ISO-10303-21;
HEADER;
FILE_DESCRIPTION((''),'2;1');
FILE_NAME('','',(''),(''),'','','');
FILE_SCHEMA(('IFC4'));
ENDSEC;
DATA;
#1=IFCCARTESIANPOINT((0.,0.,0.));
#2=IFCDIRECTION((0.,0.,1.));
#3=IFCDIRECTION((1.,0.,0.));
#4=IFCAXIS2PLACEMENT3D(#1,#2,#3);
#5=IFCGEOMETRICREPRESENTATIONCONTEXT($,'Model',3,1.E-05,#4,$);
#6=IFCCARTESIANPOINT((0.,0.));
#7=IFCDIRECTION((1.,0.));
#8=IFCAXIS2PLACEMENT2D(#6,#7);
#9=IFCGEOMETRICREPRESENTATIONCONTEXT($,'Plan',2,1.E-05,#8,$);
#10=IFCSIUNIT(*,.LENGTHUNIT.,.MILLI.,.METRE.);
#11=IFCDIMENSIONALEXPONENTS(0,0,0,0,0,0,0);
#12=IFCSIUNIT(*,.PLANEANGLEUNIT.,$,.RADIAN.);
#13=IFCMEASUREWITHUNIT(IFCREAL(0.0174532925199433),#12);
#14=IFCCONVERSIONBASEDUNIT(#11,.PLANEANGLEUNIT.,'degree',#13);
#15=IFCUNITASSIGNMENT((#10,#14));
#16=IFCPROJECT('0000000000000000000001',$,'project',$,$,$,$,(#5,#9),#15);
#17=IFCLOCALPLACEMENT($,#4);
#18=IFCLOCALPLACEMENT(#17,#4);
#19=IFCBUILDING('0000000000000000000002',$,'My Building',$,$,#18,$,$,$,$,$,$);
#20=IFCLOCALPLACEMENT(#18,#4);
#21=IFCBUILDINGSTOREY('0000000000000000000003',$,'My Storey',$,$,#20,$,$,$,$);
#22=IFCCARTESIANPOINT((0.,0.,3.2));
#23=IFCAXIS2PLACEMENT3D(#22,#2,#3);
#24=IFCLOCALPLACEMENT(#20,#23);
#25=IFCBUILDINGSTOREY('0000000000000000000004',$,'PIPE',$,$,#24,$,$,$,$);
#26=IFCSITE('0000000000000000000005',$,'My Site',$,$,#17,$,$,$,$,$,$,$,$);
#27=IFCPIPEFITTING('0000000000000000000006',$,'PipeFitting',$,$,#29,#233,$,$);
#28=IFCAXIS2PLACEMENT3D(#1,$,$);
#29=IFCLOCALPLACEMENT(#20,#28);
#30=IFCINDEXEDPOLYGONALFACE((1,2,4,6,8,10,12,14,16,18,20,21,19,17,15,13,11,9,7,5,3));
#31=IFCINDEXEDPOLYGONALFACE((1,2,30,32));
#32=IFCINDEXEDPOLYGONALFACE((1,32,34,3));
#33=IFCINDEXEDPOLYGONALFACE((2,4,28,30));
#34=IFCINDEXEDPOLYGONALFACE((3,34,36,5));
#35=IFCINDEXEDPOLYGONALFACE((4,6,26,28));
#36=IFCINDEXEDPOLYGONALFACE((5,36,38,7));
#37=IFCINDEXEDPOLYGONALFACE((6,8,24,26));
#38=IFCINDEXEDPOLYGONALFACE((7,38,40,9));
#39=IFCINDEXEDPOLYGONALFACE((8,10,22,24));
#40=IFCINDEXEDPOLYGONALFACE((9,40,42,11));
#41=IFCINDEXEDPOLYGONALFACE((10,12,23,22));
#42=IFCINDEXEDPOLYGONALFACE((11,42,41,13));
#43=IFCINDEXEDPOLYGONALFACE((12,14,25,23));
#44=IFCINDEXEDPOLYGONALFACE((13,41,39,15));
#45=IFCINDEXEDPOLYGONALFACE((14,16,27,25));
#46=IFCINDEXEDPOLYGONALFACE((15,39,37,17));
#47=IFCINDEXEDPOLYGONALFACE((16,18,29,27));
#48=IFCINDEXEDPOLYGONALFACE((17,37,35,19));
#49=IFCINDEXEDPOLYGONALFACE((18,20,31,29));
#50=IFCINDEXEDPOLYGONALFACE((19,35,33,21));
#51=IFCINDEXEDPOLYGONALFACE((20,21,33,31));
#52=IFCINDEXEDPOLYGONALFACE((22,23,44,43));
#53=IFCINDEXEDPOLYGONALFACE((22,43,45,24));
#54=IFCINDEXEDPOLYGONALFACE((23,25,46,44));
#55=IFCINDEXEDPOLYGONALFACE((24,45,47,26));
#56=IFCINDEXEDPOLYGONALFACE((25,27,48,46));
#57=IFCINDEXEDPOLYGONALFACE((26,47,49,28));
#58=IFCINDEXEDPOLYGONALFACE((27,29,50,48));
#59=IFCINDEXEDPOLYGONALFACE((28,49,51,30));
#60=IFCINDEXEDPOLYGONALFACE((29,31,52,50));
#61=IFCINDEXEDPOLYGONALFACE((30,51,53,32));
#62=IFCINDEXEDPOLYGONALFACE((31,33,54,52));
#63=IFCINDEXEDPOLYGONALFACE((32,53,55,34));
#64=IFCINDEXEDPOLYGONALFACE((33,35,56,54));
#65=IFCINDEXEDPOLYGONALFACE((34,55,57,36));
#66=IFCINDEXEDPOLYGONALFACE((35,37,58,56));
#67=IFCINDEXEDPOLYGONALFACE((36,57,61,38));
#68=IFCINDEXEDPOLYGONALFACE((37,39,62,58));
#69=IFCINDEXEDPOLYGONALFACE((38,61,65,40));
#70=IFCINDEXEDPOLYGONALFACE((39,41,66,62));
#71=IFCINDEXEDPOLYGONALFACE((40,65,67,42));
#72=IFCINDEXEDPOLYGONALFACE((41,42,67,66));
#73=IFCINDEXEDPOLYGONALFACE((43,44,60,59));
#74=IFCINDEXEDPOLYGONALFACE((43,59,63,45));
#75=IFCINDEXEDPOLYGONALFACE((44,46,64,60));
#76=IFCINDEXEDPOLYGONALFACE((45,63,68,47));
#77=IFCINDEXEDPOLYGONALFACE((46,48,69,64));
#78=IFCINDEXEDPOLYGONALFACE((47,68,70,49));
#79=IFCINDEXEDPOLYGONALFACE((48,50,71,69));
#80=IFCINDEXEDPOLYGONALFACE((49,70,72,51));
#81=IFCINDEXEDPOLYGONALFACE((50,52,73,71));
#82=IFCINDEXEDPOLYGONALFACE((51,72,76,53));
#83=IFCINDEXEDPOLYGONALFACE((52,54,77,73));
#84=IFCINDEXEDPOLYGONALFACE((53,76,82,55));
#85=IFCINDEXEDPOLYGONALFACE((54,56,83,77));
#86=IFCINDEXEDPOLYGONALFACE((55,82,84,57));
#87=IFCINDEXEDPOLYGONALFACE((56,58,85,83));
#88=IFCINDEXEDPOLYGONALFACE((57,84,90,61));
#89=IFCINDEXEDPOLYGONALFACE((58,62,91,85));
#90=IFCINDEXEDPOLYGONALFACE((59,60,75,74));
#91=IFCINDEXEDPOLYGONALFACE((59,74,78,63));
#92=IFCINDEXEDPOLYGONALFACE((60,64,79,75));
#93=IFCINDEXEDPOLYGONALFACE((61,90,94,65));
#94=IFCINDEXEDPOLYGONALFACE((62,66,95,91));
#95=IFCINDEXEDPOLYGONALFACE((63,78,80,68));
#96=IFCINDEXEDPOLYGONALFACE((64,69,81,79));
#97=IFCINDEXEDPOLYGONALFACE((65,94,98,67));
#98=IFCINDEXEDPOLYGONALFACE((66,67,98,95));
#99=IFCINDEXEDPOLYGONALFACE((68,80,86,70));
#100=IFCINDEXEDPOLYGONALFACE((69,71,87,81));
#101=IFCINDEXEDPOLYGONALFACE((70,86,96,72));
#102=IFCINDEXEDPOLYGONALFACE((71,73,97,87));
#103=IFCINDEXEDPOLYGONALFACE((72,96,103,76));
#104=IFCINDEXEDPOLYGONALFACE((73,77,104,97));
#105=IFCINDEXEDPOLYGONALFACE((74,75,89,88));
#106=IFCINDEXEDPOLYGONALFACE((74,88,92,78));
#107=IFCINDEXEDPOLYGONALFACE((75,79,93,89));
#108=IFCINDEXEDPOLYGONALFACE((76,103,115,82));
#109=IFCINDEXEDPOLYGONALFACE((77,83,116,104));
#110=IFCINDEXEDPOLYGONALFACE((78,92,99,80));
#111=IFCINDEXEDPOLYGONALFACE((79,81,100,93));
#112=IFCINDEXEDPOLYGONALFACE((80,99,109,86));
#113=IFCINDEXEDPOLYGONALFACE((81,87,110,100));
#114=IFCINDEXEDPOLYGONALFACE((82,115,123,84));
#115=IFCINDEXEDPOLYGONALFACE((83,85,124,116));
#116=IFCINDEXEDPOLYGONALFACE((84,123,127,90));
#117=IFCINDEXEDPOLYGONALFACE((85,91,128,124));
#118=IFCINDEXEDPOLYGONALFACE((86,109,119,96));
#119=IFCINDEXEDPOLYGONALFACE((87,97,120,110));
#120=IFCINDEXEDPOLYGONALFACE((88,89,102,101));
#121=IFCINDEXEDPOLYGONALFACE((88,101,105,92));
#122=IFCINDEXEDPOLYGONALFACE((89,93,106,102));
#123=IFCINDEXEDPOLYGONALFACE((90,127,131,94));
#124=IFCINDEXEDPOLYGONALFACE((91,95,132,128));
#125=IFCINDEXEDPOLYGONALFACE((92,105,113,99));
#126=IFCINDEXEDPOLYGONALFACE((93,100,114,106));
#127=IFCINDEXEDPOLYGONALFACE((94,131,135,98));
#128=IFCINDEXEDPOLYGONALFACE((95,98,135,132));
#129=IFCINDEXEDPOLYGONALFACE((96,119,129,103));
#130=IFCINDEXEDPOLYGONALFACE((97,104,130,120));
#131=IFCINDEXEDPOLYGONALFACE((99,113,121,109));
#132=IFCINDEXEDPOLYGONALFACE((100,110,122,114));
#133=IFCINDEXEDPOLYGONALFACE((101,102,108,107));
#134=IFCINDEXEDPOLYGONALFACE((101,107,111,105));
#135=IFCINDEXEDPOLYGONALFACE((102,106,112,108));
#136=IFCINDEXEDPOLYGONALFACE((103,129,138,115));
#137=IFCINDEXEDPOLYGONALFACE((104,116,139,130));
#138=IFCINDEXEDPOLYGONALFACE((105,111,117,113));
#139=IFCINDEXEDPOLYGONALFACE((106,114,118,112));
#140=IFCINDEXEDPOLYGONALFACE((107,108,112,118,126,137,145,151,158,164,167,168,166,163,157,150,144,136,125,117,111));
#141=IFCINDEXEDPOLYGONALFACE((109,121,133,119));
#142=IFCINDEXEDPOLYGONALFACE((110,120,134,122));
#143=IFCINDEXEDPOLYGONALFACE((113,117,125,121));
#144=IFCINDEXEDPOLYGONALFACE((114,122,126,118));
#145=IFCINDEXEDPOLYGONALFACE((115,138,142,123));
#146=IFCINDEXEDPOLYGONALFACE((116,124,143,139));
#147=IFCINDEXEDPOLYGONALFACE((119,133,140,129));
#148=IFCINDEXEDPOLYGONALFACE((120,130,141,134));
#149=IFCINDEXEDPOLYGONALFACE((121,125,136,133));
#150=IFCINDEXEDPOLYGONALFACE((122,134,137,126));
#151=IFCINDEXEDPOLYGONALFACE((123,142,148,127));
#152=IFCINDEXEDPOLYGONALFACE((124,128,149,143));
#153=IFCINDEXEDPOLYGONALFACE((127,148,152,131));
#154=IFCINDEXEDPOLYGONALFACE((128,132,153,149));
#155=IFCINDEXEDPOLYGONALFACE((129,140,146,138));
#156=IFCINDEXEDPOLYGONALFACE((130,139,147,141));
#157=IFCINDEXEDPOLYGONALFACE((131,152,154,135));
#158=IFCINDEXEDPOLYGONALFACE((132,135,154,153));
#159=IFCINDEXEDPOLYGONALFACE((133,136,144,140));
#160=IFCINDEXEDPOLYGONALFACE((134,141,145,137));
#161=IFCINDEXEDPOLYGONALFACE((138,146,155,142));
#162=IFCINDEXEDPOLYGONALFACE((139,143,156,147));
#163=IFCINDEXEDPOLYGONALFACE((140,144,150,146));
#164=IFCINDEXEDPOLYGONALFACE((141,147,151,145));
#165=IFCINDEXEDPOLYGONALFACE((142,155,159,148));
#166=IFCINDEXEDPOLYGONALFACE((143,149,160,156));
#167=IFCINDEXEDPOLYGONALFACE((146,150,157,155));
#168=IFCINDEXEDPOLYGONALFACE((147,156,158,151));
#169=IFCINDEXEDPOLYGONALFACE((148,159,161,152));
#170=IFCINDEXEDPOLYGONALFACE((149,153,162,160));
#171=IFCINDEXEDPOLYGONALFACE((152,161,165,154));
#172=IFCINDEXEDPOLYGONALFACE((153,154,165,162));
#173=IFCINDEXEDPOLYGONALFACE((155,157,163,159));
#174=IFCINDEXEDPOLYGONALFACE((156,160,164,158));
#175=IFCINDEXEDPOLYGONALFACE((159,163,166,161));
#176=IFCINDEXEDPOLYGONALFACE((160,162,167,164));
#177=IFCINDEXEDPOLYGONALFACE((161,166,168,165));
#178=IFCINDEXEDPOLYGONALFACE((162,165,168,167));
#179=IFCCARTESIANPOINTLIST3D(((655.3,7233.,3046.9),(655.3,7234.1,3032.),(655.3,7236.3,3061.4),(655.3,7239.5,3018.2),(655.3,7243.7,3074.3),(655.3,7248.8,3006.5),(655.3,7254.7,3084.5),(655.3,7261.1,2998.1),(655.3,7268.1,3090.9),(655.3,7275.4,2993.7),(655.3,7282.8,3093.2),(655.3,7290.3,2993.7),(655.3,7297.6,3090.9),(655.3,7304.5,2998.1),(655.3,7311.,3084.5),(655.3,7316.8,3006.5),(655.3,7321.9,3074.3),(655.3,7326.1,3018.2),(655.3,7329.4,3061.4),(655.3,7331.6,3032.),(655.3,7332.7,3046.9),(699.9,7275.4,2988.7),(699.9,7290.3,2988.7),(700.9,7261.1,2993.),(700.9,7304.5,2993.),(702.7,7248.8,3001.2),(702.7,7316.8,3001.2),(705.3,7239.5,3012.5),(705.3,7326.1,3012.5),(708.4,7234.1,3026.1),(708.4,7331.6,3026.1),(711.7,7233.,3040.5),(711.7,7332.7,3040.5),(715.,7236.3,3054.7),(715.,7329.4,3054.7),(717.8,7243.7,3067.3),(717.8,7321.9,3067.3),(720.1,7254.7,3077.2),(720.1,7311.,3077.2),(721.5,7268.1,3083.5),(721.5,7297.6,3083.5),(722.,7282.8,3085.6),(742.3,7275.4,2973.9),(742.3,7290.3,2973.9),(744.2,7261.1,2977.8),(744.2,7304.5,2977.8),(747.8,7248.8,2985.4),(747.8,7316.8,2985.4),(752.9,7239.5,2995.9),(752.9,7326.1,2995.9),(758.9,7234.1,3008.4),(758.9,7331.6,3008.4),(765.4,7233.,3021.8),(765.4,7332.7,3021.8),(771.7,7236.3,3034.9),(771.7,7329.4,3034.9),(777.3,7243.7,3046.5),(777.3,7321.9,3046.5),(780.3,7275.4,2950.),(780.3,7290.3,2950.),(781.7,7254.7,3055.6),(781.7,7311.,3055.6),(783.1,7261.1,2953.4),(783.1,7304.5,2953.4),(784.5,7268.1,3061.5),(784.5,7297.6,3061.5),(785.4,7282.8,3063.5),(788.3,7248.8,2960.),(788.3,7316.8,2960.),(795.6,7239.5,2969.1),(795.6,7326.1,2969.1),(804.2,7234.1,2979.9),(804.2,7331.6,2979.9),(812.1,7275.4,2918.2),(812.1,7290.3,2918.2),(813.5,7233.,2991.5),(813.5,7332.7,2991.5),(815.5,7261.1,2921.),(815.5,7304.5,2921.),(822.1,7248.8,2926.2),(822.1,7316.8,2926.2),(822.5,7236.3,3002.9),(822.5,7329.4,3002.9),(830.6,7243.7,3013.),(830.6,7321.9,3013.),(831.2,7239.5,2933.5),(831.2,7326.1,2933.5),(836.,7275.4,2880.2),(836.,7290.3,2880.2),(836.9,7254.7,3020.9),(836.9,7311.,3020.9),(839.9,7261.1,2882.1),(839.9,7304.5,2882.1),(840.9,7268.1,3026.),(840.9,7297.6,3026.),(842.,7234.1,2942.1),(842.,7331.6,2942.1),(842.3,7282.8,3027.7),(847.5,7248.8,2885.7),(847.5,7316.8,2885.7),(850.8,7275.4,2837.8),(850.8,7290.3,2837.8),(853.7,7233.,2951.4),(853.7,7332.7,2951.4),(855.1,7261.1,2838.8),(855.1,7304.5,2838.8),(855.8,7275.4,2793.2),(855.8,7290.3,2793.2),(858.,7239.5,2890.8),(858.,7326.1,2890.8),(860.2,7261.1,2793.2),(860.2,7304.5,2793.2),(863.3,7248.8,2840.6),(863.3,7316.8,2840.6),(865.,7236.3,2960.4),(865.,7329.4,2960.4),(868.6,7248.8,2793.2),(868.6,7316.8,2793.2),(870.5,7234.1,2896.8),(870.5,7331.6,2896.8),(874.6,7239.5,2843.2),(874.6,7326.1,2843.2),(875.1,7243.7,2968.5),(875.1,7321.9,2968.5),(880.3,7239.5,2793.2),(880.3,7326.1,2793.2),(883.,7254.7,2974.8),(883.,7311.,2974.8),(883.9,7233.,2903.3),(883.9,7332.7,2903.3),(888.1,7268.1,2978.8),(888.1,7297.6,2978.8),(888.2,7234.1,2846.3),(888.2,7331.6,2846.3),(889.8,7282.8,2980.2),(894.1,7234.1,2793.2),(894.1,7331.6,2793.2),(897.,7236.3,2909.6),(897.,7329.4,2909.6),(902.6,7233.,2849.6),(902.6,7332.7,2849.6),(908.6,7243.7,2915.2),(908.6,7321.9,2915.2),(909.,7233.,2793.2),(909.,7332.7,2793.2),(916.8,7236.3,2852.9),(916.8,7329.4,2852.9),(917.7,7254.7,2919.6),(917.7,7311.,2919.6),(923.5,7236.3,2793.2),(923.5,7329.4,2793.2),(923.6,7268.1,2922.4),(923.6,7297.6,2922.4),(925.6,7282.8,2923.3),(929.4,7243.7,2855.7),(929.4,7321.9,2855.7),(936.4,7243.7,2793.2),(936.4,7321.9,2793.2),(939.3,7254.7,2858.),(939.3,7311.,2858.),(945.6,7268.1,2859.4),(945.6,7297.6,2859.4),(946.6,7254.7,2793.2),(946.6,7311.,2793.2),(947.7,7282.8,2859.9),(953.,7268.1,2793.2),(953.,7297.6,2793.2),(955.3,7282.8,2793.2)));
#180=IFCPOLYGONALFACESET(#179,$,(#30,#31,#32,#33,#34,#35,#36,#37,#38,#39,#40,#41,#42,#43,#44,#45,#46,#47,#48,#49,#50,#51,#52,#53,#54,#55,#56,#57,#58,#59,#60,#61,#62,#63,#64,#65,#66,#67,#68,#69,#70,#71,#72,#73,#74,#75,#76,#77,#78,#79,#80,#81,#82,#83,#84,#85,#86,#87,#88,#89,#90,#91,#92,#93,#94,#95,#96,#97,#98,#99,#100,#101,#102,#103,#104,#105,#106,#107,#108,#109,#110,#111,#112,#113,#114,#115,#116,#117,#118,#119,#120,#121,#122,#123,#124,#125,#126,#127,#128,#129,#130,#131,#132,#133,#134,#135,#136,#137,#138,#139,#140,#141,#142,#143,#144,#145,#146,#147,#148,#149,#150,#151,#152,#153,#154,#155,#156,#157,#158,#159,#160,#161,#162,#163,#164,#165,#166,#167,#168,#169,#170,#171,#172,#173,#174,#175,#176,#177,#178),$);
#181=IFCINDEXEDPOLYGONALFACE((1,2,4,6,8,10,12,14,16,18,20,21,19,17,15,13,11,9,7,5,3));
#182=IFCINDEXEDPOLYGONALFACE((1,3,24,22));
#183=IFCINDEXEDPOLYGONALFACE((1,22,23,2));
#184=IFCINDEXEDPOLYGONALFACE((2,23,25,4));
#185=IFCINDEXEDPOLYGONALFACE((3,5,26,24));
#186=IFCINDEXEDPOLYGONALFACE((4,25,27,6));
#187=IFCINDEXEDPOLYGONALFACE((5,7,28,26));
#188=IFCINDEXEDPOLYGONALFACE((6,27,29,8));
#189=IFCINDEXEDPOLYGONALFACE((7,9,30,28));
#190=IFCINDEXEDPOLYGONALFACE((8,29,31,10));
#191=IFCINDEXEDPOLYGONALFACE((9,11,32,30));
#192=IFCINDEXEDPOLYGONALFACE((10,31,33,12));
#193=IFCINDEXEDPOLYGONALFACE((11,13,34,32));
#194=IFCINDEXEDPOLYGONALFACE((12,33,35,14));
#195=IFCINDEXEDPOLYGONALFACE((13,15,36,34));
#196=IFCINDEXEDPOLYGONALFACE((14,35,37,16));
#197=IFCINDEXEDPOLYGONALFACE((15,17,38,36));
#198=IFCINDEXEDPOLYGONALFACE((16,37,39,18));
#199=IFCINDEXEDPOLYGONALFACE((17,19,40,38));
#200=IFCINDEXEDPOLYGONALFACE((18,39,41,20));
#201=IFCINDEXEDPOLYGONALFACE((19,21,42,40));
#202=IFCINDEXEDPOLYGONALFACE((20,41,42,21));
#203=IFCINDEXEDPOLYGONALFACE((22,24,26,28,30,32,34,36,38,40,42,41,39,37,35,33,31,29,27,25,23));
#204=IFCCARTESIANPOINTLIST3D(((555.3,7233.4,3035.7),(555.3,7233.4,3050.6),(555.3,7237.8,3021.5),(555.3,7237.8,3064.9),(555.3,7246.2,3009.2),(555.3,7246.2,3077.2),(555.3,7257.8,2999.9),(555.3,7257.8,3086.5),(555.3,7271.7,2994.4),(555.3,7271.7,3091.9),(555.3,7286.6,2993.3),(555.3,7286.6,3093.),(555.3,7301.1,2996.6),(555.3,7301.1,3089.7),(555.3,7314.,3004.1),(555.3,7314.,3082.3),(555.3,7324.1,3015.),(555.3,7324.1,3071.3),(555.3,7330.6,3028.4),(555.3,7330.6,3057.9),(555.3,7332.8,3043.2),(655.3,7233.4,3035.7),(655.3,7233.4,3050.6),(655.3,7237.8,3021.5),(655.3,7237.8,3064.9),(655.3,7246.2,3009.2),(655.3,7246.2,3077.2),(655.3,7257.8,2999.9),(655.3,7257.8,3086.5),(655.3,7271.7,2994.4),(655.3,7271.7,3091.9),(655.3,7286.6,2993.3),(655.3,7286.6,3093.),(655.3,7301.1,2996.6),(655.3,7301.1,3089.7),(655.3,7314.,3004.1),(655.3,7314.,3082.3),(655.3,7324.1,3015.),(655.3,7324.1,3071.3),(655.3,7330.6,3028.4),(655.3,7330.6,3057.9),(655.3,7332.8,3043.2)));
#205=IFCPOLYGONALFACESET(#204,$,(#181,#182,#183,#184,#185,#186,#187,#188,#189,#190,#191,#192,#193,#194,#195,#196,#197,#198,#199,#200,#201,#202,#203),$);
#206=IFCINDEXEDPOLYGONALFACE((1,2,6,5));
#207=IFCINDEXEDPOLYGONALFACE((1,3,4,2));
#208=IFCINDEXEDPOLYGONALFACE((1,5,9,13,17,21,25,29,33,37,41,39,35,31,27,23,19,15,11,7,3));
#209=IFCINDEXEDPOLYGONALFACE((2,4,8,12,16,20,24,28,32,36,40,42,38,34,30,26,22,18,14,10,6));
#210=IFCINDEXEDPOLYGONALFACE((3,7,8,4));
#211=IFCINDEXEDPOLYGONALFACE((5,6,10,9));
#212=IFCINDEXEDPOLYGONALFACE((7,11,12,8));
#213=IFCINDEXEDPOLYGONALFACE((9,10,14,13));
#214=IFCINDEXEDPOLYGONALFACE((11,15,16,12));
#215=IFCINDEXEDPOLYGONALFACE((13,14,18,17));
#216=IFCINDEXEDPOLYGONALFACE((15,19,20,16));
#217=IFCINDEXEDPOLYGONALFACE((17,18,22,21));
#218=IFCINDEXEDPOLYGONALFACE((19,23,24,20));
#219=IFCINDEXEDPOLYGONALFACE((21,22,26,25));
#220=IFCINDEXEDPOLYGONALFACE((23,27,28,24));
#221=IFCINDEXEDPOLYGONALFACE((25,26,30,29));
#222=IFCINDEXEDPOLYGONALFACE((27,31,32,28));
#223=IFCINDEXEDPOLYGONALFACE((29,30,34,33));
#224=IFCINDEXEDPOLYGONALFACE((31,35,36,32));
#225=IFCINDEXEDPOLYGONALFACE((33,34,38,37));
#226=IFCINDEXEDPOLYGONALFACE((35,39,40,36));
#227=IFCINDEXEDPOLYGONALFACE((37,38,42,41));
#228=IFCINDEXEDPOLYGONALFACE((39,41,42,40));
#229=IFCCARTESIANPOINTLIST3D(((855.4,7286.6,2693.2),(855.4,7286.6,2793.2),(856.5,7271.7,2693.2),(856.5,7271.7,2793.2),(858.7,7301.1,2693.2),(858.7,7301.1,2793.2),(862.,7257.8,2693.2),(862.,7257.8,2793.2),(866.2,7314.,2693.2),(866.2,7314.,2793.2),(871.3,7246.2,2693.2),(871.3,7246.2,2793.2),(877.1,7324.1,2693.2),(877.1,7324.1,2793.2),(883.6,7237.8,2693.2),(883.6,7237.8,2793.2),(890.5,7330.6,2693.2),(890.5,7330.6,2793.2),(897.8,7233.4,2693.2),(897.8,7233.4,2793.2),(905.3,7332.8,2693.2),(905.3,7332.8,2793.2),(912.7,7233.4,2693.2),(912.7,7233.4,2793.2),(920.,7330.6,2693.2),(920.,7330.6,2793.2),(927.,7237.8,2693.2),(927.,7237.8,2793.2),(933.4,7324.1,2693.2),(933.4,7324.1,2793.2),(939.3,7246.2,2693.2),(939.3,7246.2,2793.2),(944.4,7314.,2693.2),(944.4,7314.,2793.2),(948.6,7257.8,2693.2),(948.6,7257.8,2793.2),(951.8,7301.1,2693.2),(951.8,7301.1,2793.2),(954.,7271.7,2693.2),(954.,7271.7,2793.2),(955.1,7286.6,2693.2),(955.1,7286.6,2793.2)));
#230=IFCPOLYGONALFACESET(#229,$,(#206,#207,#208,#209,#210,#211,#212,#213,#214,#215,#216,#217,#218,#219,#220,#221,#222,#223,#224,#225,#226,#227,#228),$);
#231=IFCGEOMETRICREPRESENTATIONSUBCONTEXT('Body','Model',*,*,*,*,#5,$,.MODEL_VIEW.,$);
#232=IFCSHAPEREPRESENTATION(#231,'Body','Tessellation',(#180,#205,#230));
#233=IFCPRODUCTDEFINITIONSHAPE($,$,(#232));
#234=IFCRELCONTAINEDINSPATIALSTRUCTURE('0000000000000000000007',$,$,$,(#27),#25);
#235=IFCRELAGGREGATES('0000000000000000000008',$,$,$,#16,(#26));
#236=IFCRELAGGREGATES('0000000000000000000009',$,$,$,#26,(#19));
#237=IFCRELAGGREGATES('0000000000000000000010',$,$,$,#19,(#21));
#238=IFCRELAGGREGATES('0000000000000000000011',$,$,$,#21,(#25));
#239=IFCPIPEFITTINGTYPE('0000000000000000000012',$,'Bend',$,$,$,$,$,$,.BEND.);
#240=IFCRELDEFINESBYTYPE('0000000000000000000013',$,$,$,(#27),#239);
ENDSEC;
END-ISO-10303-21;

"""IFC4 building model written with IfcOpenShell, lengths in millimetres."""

from ifc_helpers import new_model, entity, si_unit, converted_unit, frame, origin_with_axes, origin_2d_with_axis, place, context, subcontext, project, spatial, circle, extrude, source, transform, mapped, type_object, type_shapes, element, save


model = new_model("IFC4")

# Units and contexts
model_context = context("Model", 3, precision=1e-05, world=origin_with_axes())
plan_context = context("Plan", 2, precision=1e-05, world=origin_2d_with_axis())
body_context = subcontext(model_context, "Body", "Model", "MODEL_VIEW")
ifc_project = project(units=[si_unit("LENGTHUNIT", "METRE", prefix="MILLI"), converted_unit("PLANEANGLEUNIT", "degree", entity("IfcReal", 0.0174532925199433), si_unit("PLANEANGLEUNIT", "RADIAN"), dimensions=[0, 0, 0, 0, 0, 0, 0])], contexts=[model_context, plan_context])

# Site, building, storeys
site_placement = place(None, origin_with_axes())
site = spatial("IfcSite", under=ifc_project, at=site_placement, Name="My Site")
building_placement = place(site_placement, origin_with_axes())
building = spatial("IfcBuilding", under=site, at=building_placement, Name="My Building")
storey_1_placement = place(building_placement, origin_with_axes())
storey_1 = spatial("IfcBuildingStorey", under=building, at=storey_1_placement, Name="My Storey")
storey_2_placement = place(storey_1_placement, frame((0.0, 0.0, 3.2), z_axis=(0.0, 0.0, 1.0), x_axis=(1.0, 0.0, 0.0)))
storey_2 = spatial("IfcBuildingStorey", under=storey_1, at=storey_2_placement, Name="PIPE")

# Pipe fitting
pipe_fitting_type = type_object("IfcPipeFittingType", Name="Bend", PredefinedType="BEND")
shared_shape = source(origin_with_axes(), body_context, "Body", "SolidModel", [
    entity("IfcSweptDiskSolid", entity("IfcIndexedPolyCurve", entity("IfcCartesianPointList3D", [[0.0, 0.0, 100.0], [0.0, -73.2, 276.8], [0.0, -250.0, 350.0]]), [entity("IfcArcIndex", [1, 2, 3])]), 50.0),
    extrude(circle(Radius=50.0), origin_with_axes(), (0.0, 0.0, 1.0), 100.0),
    extrude(circle(Radius=50.0), frame((0.0, -250.0, 350.0), z_axis=(0.0, -1.0, 0.0), x_axis=(1.0, 0.0, 0.0)), (0.0, 0.0, 1.0), 100.0),
])
type_shapes(pipe_fitting_type, [shared_shape])
for number, where, z_axis, x_axis, name in (
    (1, (555.3, 7282.8, 3040.0), (1.0, 0.0, 0.0), (0.0, 1.0, 0.0), "PipeFitting"),
):
    element("IfcPipeFitting", number, at=place(storey_2_placement, frame(where, z_axis=z_axis, x_axis=x_axis)), inside=storey_2, type_object=pipe_fitting_type, Name=name, context=body_context, shape_type="MappedRepresentation", body=[
        mapped(shared_shape, transform((0.0, 0.0, 0.0), x_axis=(1.0, 0.0, 0.0), y_axis=(0.0, 1.0, 0.0), z_axis=(0.0, 0.0, 1.0), scale=1.0)),
    ])

save(model, "model.ifc")
